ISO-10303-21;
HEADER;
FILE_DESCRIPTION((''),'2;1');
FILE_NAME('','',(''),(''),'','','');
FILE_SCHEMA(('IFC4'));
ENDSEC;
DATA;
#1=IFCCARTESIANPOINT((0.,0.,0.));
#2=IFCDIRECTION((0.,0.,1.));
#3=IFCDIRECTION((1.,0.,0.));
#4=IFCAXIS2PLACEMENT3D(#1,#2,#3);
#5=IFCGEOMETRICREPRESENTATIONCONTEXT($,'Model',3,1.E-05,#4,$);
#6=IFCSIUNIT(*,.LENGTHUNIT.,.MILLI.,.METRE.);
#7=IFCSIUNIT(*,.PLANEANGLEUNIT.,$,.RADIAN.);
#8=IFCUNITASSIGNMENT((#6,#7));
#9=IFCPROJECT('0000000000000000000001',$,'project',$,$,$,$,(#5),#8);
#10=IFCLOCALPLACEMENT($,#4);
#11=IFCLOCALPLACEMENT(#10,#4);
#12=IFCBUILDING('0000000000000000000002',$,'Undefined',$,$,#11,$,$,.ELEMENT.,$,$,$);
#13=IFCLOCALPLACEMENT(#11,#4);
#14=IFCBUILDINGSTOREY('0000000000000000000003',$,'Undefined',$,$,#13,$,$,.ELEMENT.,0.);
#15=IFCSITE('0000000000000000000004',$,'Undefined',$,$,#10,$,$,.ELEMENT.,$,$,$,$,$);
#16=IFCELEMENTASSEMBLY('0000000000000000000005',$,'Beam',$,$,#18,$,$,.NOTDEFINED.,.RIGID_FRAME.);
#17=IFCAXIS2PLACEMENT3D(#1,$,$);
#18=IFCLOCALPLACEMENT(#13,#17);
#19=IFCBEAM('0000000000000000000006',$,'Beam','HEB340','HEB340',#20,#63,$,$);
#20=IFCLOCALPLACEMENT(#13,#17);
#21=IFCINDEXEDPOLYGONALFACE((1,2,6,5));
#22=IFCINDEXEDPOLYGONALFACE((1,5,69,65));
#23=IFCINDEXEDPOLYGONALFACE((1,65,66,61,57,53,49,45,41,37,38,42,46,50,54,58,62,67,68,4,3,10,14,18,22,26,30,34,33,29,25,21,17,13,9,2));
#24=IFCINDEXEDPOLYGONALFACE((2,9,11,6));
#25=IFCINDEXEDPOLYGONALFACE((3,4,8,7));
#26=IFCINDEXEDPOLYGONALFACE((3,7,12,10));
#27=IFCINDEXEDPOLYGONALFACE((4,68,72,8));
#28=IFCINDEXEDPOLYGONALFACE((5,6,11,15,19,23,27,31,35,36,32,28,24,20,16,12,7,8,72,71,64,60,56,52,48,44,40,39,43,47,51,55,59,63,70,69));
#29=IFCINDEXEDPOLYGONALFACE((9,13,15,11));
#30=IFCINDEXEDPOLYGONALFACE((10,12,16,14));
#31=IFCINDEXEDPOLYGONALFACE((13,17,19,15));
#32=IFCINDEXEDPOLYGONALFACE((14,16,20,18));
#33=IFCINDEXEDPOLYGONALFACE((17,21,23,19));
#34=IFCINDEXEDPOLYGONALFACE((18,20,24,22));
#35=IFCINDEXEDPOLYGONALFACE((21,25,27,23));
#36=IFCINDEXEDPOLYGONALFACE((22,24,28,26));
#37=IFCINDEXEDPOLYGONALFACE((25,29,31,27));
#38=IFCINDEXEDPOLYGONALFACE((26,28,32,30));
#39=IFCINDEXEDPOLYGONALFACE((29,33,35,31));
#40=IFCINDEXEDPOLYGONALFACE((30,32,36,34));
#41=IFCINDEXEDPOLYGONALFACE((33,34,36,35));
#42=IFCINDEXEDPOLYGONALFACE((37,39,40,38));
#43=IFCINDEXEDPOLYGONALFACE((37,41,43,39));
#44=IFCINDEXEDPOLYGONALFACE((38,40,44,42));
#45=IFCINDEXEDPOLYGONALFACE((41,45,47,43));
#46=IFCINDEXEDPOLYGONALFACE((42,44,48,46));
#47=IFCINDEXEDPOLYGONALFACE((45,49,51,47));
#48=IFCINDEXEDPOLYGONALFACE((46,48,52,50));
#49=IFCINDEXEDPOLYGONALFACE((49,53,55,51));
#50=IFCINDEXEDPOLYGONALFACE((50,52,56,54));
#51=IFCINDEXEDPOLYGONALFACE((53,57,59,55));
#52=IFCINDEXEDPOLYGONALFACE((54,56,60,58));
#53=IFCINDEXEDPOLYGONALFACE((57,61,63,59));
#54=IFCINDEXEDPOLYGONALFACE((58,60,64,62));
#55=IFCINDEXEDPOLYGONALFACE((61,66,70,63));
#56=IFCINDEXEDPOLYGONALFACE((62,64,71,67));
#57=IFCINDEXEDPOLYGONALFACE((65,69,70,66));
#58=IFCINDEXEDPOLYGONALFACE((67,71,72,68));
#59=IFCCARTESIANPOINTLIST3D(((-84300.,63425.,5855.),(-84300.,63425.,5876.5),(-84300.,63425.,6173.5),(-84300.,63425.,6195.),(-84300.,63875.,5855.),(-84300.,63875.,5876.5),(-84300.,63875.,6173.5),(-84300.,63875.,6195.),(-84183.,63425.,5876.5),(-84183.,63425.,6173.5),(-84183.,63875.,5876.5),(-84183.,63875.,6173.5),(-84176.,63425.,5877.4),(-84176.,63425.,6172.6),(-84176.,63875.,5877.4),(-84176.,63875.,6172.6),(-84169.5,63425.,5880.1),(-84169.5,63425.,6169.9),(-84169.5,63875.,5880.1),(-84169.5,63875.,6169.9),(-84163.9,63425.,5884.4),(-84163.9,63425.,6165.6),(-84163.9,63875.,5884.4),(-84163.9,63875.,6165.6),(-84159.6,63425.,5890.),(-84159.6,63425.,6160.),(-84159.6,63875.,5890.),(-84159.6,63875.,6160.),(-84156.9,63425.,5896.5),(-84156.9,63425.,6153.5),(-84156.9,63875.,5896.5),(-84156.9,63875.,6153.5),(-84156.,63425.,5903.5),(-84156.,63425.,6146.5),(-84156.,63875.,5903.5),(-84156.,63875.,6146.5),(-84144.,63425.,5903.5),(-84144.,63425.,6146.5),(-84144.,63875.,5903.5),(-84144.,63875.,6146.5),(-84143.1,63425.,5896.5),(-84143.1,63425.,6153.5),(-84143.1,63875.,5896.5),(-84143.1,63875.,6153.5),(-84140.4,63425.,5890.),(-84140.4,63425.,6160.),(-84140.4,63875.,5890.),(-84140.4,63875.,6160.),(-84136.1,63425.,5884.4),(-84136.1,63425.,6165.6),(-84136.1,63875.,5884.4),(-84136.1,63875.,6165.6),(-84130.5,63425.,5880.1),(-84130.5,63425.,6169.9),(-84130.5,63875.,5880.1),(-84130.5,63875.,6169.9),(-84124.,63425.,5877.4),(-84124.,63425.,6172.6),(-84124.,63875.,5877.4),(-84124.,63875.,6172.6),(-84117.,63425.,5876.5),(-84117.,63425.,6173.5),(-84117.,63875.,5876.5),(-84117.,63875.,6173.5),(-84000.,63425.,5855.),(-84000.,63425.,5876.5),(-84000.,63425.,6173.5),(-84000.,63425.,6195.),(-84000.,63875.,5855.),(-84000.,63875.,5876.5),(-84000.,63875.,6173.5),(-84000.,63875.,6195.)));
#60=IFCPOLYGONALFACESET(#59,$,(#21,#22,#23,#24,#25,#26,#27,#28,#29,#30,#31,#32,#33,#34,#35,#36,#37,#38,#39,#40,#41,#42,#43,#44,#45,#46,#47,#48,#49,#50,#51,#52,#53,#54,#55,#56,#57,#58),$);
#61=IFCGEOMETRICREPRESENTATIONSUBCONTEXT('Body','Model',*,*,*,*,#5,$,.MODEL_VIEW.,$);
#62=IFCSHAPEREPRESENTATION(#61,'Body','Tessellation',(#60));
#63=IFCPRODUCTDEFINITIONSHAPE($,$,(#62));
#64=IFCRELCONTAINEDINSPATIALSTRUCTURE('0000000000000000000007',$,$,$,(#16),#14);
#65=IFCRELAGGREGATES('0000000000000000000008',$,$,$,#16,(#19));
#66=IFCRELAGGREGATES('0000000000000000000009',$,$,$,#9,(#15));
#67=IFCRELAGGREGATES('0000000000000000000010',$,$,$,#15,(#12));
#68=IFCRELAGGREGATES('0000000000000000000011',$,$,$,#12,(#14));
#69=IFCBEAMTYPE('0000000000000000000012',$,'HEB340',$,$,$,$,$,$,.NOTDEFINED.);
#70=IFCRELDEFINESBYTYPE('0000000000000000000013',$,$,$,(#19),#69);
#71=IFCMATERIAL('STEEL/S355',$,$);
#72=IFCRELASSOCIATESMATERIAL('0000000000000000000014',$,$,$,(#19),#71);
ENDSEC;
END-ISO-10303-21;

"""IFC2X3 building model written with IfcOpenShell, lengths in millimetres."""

from ifc_helpers import new_model, si_unit, frame, origin_with_axes, origin_2d_with_axis, place, context, subcontext, project, spatial, i_section, extrude, material, type_object, element, aggregate, save


model = new_model("IFC2X3")

# Units and contexts
model_context = context("Model", 3, precision=1e-05, world=origin_with_axes())
body_context = subcontext(model_context, "Body", "Model", "MODEL_VIEW")
ifc_project = project(units=[si_unit("LENGTHUNIT", "METRE", prefix="MILLI"), si_unit("PLANEANGLEUNIT", "RADIAN")], contexts=[model_context])

# Site, building, storey
site_placement = place(None, origin_with_axes())
site = spatial("IfcSite", under=ifc_project, at=site_placement, Name="Undefined", CompositionType="ELEMENT")
building_placement = place(site_placement, origin_with_axes())
building = spatial("IfcBuilding", under=site, at=building_placement, Name="Undefined", CompositionType="ELEMENT")
storey_placement = place(building_placement, origin_with_axes())
storey = spatial("IfcBuildingStorey", under=building, at=storey_placement, Name="Undefined", CompositionType="ELEMENT", Elevation=0.0)

# Element assembly, beam
ifc_material = material(Name="STEEL/S355")
assembly_1_placement = place(storey_placement, origin_with_axes())
assembly_1 = element("IfcElementAssembly", 1, at=assembly_1_placement, inside=storey, Name="Beam", AssemblyPlace="NOTDEFINED", PredefinedType="RIGID_FRAME")
beam_type_1 = type_object("IfcBeamType", Name="HEB340", PredefinedType="NOTDEFINED")
beam_1_placement = place(assembly_1_placement, frame((-84150.0, 63875.0, 6025.0), z_axis=(0.0, 0.0, 1.0), x_axis=(0.0, -1.0, 0.0)))
beam_1 = element("IfcBeam", 2, at=beam_1_placement, type_object=beam_type_1, material=ifc_material, Name="Beam", Description="HEB340", ObjectType="HEB340", context=body_context, shape_type="SweptSolid", body=[
    extrude(i_section(OverallWidth=300.0, OverallDepth=340.0, WebThickness=12.0, FlangeThickness=21.5, FilletRadius=27.0, at=origin_2d_with_axis()), frame((450.0, 0.0, 0.0), z_axis=(-1.0, 0.0, 0.0), x_axis=(0.0, -1.0, 0.0)), (0.0, 0.0, 1.0), 450.0),
])
aggregate(assembly_1, [beam_1])

save(model, "model.ifc")
